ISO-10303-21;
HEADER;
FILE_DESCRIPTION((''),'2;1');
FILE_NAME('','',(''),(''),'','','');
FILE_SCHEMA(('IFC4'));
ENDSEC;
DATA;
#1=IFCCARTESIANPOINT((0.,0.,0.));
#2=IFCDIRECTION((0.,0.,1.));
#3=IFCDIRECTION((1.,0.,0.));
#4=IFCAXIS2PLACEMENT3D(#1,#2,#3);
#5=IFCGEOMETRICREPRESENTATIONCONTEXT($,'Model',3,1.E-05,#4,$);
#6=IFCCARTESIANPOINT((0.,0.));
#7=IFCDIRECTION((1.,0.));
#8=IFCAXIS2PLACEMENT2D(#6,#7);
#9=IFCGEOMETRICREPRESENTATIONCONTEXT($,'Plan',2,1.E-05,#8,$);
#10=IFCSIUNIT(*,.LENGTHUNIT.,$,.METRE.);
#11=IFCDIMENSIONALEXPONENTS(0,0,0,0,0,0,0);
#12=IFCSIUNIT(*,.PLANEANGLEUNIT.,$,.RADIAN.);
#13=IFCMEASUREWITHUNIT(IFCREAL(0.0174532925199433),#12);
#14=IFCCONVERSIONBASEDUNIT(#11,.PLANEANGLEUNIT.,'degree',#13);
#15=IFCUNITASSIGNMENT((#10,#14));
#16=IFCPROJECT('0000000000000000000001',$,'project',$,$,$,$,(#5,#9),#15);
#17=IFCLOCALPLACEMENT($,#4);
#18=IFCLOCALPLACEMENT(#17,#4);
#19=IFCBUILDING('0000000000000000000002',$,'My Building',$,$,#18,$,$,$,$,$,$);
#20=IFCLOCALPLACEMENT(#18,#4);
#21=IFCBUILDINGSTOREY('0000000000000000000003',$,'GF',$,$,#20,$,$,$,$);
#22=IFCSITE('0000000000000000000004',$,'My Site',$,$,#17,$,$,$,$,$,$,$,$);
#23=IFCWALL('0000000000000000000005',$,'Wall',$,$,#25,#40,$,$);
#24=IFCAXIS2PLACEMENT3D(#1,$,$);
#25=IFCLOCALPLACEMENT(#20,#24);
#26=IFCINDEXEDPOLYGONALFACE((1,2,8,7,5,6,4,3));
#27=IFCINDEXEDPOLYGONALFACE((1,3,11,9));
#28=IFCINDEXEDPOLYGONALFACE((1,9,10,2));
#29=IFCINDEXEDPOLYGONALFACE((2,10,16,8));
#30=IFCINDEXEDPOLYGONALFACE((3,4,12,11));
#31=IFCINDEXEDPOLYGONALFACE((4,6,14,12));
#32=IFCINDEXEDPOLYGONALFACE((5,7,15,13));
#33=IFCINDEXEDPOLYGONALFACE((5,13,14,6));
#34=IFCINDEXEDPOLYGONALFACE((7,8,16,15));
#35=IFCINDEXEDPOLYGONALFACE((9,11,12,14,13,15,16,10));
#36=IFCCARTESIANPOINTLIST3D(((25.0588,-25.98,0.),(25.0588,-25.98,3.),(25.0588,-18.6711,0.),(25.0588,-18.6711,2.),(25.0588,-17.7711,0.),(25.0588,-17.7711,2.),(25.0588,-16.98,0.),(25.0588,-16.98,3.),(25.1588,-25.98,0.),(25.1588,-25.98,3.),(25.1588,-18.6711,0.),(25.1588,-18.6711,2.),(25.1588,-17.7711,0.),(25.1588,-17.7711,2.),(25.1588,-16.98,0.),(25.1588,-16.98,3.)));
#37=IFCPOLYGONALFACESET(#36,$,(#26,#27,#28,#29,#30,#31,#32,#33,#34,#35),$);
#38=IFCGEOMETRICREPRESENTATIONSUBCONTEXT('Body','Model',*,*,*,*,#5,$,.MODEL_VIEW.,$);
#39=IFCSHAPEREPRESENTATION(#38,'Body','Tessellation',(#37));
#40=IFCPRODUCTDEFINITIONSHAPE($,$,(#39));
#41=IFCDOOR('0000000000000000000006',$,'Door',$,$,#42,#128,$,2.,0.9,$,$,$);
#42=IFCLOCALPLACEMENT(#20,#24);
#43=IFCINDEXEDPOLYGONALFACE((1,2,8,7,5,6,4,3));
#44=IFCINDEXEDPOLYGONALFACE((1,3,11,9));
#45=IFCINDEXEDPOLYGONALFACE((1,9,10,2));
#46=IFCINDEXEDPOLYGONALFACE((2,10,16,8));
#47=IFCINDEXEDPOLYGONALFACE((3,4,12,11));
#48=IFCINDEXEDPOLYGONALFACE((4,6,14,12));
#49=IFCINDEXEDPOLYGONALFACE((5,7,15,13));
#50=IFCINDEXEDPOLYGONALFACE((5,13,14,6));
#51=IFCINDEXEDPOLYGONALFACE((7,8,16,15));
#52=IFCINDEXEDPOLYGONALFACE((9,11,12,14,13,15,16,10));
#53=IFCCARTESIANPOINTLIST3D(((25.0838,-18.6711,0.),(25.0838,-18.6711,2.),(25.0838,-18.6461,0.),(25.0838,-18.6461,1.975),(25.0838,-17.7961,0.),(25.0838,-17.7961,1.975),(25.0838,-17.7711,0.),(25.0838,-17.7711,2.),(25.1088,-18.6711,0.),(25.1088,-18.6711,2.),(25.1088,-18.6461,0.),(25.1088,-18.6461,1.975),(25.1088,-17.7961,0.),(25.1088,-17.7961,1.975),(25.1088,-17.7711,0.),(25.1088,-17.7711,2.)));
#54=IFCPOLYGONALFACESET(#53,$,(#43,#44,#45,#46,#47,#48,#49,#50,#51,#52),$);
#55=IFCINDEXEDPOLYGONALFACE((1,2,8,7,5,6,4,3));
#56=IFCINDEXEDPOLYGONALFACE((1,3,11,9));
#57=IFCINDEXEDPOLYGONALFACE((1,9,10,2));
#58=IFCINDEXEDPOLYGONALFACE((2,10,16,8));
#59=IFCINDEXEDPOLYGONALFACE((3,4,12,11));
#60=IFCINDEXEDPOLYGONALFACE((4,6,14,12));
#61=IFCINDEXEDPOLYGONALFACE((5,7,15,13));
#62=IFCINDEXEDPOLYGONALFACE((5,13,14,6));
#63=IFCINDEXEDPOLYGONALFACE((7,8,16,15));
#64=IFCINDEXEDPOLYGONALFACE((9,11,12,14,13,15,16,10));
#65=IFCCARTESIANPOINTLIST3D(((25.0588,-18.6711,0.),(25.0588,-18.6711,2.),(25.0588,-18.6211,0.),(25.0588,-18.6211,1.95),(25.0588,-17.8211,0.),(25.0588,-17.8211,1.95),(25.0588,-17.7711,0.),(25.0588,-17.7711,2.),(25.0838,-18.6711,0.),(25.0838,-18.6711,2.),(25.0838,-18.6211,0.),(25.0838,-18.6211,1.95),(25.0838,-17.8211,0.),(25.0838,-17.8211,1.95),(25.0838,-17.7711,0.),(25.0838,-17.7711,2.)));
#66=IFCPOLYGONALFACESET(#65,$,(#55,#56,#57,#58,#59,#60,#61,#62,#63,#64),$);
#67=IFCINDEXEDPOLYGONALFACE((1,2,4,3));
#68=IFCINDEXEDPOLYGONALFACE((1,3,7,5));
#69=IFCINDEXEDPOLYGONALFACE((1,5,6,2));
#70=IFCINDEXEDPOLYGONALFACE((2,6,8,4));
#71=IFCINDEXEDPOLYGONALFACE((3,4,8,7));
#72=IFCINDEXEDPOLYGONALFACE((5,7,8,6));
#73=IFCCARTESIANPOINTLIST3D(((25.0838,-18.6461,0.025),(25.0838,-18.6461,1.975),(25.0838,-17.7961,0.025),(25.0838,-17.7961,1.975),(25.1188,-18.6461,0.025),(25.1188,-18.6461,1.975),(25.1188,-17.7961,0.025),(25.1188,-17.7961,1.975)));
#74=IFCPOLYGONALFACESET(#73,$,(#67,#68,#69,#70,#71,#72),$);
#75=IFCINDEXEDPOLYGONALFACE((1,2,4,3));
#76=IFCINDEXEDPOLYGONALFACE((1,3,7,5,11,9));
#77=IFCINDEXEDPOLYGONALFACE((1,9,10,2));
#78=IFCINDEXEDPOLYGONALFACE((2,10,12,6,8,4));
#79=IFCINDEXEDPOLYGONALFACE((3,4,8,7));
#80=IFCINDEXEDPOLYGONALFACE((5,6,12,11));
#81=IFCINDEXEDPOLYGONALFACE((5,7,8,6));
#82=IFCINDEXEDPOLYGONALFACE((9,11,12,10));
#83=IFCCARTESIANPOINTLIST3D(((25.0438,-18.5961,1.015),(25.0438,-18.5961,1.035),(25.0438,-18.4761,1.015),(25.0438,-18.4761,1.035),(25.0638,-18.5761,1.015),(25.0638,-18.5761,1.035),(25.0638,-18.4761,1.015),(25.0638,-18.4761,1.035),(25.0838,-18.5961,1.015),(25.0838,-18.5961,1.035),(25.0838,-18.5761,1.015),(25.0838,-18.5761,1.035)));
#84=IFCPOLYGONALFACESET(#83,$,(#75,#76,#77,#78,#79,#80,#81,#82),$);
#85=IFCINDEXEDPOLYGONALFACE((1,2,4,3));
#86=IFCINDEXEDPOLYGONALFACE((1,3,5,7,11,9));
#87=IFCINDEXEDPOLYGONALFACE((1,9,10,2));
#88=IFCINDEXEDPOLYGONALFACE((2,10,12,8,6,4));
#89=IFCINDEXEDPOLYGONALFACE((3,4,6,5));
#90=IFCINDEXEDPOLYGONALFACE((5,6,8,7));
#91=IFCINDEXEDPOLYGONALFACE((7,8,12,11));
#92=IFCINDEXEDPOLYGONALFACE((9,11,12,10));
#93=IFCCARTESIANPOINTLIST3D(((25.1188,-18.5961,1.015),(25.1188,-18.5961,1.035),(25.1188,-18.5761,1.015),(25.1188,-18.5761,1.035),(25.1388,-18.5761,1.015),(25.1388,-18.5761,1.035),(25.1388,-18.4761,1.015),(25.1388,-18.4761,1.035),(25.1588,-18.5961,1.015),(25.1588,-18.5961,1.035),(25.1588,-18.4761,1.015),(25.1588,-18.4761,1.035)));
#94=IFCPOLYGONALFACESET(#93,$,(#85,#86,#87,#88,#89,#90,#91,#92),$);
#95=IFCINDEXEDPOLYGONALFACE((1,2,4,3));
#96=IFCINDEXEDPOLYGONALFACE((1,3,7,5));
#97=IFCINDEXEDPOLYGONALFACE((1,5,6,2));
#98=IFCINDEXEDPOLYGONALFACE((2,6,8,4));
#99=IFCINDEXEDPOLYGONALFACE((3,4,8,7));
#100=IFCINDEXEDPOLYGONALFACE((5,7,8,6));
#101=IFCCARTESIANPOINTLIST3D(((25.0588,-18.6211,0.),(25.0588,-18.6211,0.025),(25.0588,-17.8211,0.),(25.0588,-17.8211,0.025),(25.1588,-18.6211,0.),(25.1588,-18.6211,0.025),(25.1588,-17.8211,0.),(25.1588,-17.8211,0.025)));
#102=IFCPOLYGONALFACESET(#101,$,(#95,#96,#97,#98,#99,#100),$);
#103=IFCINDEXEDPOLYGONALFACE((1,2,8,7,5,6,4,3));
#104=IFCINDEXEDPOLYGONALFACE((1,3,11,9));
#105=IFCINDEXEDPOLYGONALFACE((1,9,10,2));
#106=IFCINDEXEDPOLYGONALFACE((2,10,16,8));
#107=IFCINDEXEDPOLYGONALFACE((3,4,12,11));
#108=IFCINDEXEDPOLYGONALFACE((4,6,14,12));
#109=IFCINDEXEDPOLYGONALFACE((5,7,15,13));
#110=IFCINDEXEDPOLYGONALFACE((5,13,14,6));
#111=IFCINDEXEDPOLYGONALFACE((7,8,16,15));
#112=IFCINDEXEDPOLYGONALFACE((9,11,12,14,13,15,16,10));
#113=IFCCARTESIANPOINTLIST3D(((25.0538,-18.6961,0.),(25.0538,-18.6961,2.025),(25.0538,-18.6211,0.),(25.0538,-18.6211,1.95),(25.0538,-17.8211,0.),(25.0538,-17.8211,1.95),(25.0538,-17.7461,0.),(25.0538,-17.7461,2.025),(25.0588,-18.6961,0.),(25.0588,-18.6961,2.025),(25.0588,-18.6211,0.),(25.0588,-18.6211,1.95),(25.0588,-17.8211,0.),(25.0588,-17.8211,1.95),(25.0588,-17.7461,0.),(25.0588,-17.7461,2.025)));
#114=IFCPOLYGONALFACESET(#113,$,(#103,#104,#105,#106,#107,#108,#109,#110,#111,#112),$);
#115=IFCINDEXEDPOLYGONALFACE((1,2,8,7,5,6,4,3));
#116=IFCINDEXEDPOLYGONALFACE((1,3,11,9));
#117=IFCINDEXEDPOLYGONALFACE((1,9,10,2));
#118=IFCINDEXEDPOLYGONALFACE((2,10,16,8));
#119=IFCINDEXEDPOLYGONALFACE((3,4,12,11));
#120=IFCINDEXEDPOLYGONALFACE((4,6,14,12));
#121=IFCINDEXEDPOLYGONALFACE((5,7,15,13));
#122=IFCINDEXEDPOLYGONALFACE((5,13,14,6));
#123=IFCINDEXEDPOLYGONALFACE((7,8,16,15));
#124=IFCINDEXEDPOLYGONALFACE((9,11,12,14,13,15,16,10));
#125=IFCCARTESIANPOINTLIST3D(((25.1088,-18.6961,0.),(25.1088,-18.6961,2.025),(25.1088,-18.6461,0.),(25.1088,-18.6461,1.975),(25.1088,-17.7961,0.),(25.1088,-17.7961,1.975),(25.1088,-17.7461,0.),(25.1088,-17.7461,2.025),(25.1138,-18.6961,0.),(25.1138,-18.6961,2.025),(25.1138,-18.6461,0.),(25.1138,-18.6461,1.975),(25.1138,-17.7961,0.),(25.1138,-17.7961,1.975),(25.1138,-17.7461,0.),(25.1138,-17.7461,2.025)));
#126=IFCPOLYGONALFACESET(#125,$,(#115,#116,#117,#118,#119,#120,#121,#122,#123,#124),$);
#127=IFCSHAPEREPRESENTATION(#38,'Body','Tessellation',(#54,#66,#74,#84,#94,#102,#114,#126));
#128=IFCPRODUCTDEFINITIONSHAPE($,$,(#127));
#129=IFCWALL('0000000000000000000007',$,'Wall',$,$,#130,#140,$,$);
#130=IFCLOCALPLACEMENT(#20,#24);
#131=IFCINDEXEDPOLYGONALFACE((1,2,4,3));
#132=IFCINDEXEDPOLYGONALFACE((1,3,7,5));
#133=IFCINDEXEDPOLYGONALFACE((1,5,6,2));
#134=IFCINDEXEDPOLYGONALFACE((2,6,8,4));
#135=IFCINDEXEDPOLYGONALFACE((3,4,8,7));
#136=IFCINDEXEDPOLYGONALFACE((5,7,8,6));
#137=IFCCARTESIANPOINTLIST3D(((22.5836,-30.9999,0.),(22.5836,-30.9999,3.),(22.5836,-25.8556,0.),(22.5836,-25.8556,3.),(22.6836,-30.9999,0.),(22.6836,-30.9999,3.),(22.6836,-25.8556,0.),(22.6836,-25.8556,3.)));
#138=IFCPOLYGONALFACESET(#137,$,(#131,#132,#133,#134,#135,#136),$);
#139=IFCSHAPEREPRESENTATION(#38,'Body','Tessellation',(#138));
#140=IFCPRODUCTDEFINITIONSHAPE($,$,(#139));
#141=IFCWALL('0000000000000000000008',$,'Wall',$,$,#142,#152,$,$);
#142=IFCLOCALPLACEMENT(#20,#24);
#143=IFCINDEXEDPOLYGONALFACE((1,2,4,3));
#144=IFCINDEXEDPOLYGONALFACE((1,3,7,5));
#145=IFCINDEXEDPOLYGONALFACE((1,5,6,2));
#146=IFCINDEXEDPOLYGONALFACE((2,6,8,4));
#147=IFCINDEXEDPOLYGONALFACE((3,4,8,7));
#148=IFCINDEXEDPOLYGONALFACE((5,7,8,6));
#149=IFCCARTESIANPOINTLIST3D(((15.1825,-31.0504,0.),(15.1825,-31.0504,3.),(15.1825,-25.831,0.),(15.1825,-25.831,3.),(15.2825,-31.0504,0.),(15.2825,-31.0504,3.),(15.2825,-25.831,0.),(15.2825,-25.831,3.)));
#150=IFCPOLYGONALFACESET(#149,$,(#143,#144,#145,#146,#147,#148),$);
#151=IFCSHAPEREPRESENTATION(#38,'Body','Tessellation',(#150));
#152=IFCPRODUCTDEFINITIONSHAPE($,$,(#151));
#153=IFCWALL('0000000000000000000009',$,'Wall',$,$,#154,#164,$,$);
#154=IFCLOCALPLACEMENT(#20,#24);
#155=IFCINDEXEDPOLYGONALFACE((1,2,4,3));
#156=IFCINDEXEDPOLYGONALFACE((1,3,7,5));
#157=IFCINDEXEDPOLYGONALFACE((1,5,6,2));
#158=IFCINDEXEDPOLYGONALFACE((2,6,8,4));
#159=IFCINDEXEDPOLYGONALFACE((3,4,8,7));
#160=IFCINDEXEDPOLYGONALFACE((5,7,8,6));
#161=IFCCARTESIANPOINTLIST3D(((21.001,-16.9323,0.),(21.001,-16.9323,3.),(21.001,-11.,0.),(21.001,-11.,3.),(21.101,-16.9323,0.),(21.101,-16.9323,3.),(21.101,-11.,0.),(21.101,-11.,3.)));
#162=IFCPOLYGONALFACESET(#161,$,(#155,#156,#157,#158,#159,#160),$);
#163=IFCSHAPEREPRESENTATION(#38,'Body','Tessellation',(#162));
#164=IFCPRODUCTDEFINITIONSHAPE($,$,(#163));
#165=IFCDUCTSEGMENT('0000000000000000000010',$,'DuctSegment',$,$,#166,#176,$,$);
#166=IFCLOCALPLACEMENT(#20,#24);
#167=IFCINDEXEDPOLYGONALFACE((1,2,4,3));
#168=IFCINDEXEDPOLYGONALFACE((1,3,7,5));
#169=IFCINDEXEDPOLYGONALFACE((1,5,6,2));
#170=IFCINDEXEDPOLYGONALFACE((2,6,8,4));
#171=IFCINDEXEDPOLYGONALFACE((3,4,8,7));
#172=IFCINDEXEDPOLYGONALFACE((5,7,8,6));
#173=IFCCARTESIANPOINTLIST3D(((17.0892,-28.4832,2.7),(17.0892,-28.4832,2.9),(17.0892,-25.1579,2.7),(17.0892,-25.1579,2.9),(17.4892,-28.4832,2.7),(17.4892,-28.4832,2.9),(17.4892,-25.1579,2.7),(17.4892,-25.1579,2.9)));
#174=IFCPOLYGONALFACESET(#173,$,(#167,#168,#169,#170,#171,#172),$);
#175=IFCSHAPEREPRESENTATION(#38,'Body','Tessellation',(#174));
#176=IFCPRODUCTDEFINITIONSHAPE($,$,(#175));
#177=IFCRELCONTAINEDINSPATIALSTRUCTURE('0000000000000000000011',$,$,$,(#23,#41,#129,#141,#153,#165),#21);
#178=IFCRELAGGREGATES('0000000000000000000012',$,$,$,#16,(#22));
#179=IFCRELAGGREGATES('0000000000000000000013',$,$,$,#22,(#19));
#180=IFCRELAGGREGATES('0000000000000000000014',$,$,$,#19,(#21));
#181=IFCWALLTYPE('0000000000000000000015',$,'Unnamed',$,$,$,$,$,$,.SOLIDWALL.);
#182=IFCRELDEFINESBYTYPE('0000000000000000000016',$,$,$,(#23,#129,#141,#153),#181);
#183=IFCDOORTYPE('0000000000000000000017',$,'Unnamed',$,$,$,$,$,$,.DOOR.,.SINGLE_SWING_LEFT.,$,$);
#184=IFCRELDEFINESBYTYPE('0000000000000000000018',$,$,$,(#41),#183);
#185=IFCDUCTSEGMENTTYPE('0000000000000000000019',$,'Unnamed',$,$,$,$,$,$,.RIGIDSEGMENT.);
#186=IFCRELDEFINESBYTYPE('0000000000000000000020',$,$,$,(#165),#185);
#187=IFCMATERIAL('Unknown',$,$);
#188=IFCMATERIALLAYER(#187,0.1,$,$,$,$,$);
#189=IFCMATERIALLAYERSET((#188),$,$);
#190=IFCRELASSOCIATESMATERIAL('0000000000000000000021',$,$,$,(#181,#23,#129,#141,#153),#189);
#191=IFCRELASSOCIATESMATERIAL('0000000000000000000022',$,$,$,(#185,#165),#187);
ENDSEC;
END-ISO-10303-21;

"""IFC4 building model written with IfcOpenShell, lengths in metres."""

from ifc_helpers import new_model, entity, si_unit, converted_unit, frame, origin_with_axes, origin_2d_with_axis, place, context, subcontext, project, spatial, line, indexed_curve, rectangle, outline, extrude, shape, source, transform, mapped, material, layer, layer_set, layer_usage, material_profile, profile_set, profile_usage, type_object, type_shapes, element, fill, save


model = new_model("IFC4")

# Units and contexts
model_context = context("Model", 3, precision=1e-05, world=origin_with_axes())
plan_context = context("Plan", 2, precision=1e-05, world=origin_2d_with_axis())
body_context_1 = subcontext(model_context, "Body", "Model", "MODEL_VIEW")
body_context_2 = subcontext(plan_context, "Body", "Plan", "PLAN_VIEW")
ifc_project = project(units=[si_unit("LENGTHUNIT", "METRE"), converted_unit("PLANEANGLEUNIT", "degree", entity("IfcReal", 0.0174532925199433), si_unit("PLANEANGLEUNIT", "RADIAN"), dimensions=[0, 0, 0, 0, 0, 0, 0])], contexts=[model_context, plan_context])

# Site, building, storey
site_placement = place(None, origin_with_axes())
site = spatial("IfcSite", under=ifc_project, at=site_placement, Name="My Site")
building_placement = place(site_placement, origin_with_axes())
building = spatial("IfcBuilding", under=site, at=building_placement, Name="My Building")
storey_placement = place(building_placement, origin_with_axes())
storey = spatial("IfcBuildingStorey", under=building, at=storey_placement, Name="GF")

# Shared definitions
ifc_material = material(Name="Unknown")
ifc_layer = layer(ifc_material, 0.1)
ifc_layer_set = layer_set([ifc_layer])
wall_type = type_object("IfcWallType", Name="Unnamed", PredefinedType="SOLIDWALL", material=ifc_layer_set)

# Shared definitions
shared_shape_1 = source(origin_with_axes(), body_context_1, "Body", "SweptSolid", [
    extrude(outline(indexed_curve([(0.0, 0.0), (0.9, 0.0), (0.9, 2.0), (0.0, 2.0)], segments=[line(1, 2, 3, 4, 1)])), frame((0.0, -0.6, 0.0), z_axis=(0.0, -1.0, 0.0), x_axis=(1.0, 0.0, 0.0)), (0.0, 0.0, -1.0), 1.2),
])
door_type = type_object("IfcDoorType", Name="Unnamed", OperationType="SINGLE_SWING_LEFT", PredefinedType="DOOR")
shared_shape_2 = source(origin_with_axes(), body_context_1, "Body", "SweptSolid", [
    extrude(outline(indexed_curve([(0.0, 0.0), (0.0, 2.0), (0.9, 2.0), (0.9, 0.0), (0.875, 0.0), (0.875, 1.975), (0.025, 1.975), (0.025, 0.0)], segments=[line(1, 2, 3, 4, 5, 6, 7, 8, 1)])), frame((0.0, 0.025, 0.0), z_axis=(0.0, -1.0, 0.0), x_axis=(1.0, 0.0, 0.0)), (0.0, 0.0, -1.0), 0.025),
    extrude(outline(indexed_curve([(0.0, 0.0), (0.0, 2.0), (0.9, 2.0), (0.9, 0.0), (0.85, 0.0), (0.85, 1.95), (0.05, 1.95), (0.05, 0.0)], segments=[line(1, 2, 3, 4, 5, 6, 7, 8, 1)])), frame((0.0, 0.0, 0.0), z_axis=(0.0, -1.0, 0.0), x_axis=(1.0, 0.0, 0.0)), (0.0, 0.0, -1.0), 0.025),
    extrude(outline(indexed_curve([(0.0, 0.0), (0.85, 0.0), (0.85, 0.035), (0.0, 0.035)], segments=[line(1, 2, 3, 4, 1)])), frame((0.025, 0.025, 0.025), z_axis=(0.0, 0.0, 1.0), x_axis=(1.0, 0.0, 0.0)), (0.0, 0.0, 1.0), 1.95),
    extrude(outline(indexed_curve([(0.0, 0.0), (0.0, -0.04), (-0.12, -0.04), (-0.12, -0.02), (-0.02, -0.02), (-0.02, 0.0)], segments=[line(1, 2, 3, 4, 5, 6, 1)])), frame((0.825, 0.025, 1.015), z_axis=(0.0, 0.0, 1.0), x_axis=(1.0, 0.0, 0.0)), (0.0, 0.0, 1.0), 0.02),
    extrude(outline(indexed_curve([(0.0, 0.0), (0.0, 0.04), (-0.12, 0.04), (-0.12, 0.02), (-0.02, 0.02), (-0.02, 0.0)], segments=[line(1, 2, 3, 4, 5, 6, 1)])), frame((0.825, 0.06, 1.015), z_axis=(0.0, 0.0, 1.0), x_axis=(1.0, 0.0, 0.0)), (0.0, 0.0, 1.0), 0.02),
    extrude(outline(indexed_curve([(0.0, 0.0), (0.8, 0.0), (0.8, 0.1), (0.0, 0.1)], segments=[line(1, 2, 3, 4, 1)])), frame((0.05, 0.0, 0.0), z_axis=(0.0, 0.0, 1.0), x_axis=(1.0, 0.0, 0.0)), (0.0, 0.0, 1.0), 0.025),
    extrude(outline(indexed_curve([(0.0, 0.0), (0.0, 2.025), (0.95, 2.025), (0.95, 0.0), (0.875, 0.0), (0.875, 1.95), (0.075, 1.95), (0.075, 0.0)], segments=[line(1, 2, 3, 4, 5, 6, 7, 8, 1)])), frame((-0.025, -0.005, 0.0), z_axis=(0.0, -1.0, 0.0), x_axis=(1.0, 0.0, 0.0)), (0.0, 0.0, -1.0), 0.005),
    extrude(outline(indexed_curve([(0.0, 0.0), (0.0, 2.025), (0.95, 2.025), (0.95, 0.0), (0.9, 0.0), (0.9, 1.975), (0.05, 1.975), (0.05, 0.0)], segments=[line(1, 2, 3, 4, 5, 6, 7, 8, 1)])), frame((-0.025, 0.05, 0.0), z_axis=(0.0, -1.0, 0.0), x_axis=(1.0, 0.0, 0.0)), (0.0, 0.0, -1.0), 0.005),
])
shared_shape_3 = source(origin_with_axes(), body_context_2, "Body", "Curve2D", [
    entity("IfcIndexedPolyCurve", entity("IfcCartesianPointList2D", [[0.0, 0.0], [0.0, 0.05], [0.025, 0.05], [0.025, 0.025], [0.05, 0.025], [0.05, 0.0]]), [entity("IfcLineIndex", [1, 2, 3, 4, 5, 6, 1])]),
    entity("IfcIndexedPolyCurve", entity("IfcCartesianPointList2D", [[0.9, 0.0], [0.9, 0.05], [0.875, 0.05], [0.875, 0.025], [0.85, 0.025], [0.85, 0.0]]), [entity("IfcLineIndex", [1, 2, 3, 4, 5, 6, 1])]),
    entity("IfcTrimmedCurve", entity("IfcEllipse", entity("IfcAxis2Placement2D", entity("IfcCartesianPoint", [0.06, 0.05]), entity("IfcDirection", [1.0, 0.0])), 0.815, 0.85), [entity("IfcCartesianPoint", [0.875, 0.05])], [entity("IfcCartesianPoint", [0.06, 0.9])], True, "CARTESIAN"),
    entity("IfcIndexedPolyCurve", entity("IfcCartesianPointList2D", [[0.025, 0.05], [0.06, 0.05], [0.06, 0.9], [0.025, 0.9]]), [entity("IfcLineIndex", [1, 2, 3, 4, 1])]),
])
type_shapes(door_type, [shared_shape_2, shared_shape_3])

# Wall, opening, door
ifc_layer_usage_1 = layer_usage(ifc_layer_set, "AXIS2", "POSITIVE", 0.0)
wall_1_placement = place(storey_placement, frame((25.0588, -16.98, 0.0), z_axis=(0.0, 0.0, 1.0), x_axis=(0.0, -1.0, 0.0)))
wall_1 = element("IfcWall", 1, at=wall_1_placement, inside=storey, type_object=wall_type, material=ifc_layer_usage_1, Name="Wall", context=body_context_1, shape_type="SweptSolid", body=[
    extrude(outline(indexed_curve([(0.0, 0.0), (0.0, 0.1), (9.0, 0.1), (9.0, 0.0)], segments=[line(1, 2, 3, 4, 1)])), origin_with_axes(), (0.0, 0.0, 1.0), 3.0),
])
opening_1_placement = place(wall_1_placement, frame((0.7911, 0.0, 0.0), z_axis=(0.0, 0.0, 1.0), x_axis=(1.0, 0.0, 0.0)))
opening_1 = element("IfcOpeningElement", 2, at=opening_1_placement, cuts=wall_1, PredefinedType="OPENING", context=body_context_1, shape_type="MappedRepresentation", body=[
    mapped(shared_shape_1, transform((0.0, 0.0, 0.0), x_axis=(1.0, 0.0, 0.0), y_axis=(0.0, 1.0, 0.0), z_axis=(0.0, 0.0, 1.0), scale=1.0)),
])
door_1_placement = place(opening_1_placement, frame((0.0, 0.0, 0.0), z_axis=(0.0, 0.0, 1.0), x_axis=(1.0, 0.0, 0.0)))
door_1 = element("IfcDoor", 3, at=door_1_placement, inside=storey, type_object=door_type, Name="Door", OverallHeight=2.0, OverallWidth=0.9, shapes=[
    shape(body_context_1, "Body", "MappedRepresentation", [mapped(shared_shape_2, transform((0.0, 0.0, 0.0), x_axis=(1.0, 0.0, 0.0), y_axis=(0.0, 1.0, 0.0), z_axis=(0.0, 0.0, 1.0), scale=1.0))]),
    shape(body_context_2, "Body", "MappedRepresentation", [mapped(shared_shape_3, transform((0.0, 0.0, 0.0), x_axis=(1.0, 0.0, 0.0), y_axis=(0.0, 1.0, 0.0), z_axis=(0.0, 0.0, 1.0), scale=1.0))]),
])
fill(opening_1, door_1)

# Walls
ifc_layer_usage_2 = layer_usage(ifc_layer_set, "AXIS2", "POSITIVE", 0.0)
wall_2_placement = place(storey_placement, frame((22.5836, -25.8556, 0.0), z_axis=(0.0, 0.0, 1.0), x_axis=(0.0, -1.0, 0.0)))
element("IfcWall", 4, at=wall_2_placement, inside=storey, type_object=wall_type, material=ifc_layer_usage_2, Name="Wall", context=body_context_1, shape_type="SweptSolid", body=[
    extrude(outline(indexed_curve([(0.0, 0.0), (0.0, 0.1), (5.1443, 0.1), (5.1443, 0.0)], segments=[line(1, 2, 3, 4, 1)])), origin_with_axes(), (0.0, 0.0, 1.0), 3.0),
])
ifc_layer_usage_3 = layer_usage(ifc_layer_set, "AXIS2", "POSITIVE", 0.0)
wall_3_placement = place(storey_placement, frame((15.1825, -25.831, 0.0), z_axis=(0.0, 0.0, 1.0), x_axis=(0.0, -1.0, 0.0)))
element("IfcWall", 5, at=wall_3_placement, inside=storey, type_object=wall_type, material=ifc_layer_usage_3, Name="Wall", context=body_context_1, shape_type="SweptSolid", body=[
    extrude(outline(indexed_curve([(0.0, 0.0), (0.0, 0.1), (5.2194, 0.1), (5.2194, 0.0)], segments=[line(1, 2, 3, 4, 1)])), origin_with_axes(), (0.0, 0.0, 1.0), 3.0),
])
ifc_layer_usage_4 = layer_usage(ifc_layer_set, "AXIS2", "POSITIVE", 0.0)
wall_4_placement = place(storey_placement, frame((21.101, -16.9323, 0.0), z_axis=(0.0, 0.0, 1.0), x_axis=(0.0, 1.0, 0.0)))
element("IfcWall", 6, at=wall_4_placement, inside=storey, type_object=wall_type, material=ifc_layer_usage_4, Name="Wall", context=body_context_1, shape_type="SweptSolid", body=[
    extrude(outline(indexed_curve([(0.0, 0.0), (0.0, 0.1), (5.9323, 0.1), (5.9323, 0.0)], segments=[line(1, 2, 3, 4, 1)])), origin_with_axes(), (0.0, 0.0, 1.0), 3.0),
])

# Duct segment
ifc_material_profile_1 = material_profile(ifc_material, rectangle(XDim=0.4, YDim=0.2))
ifc_profile_set_1 = profile_set([ifc_material_profile_1])
ifc_profile_usage_1 = profile_usage(ifc_profile_set_1, cardinal=5)
duct_segment_type = type_object("IfcDuctSegmentType", Name="Unnamed", PredefinedType="RIGIDSEGMENT", material=ifc_profile_set_1)
duct_segment_1_placement = place(storey_placement, frame((17.2892, -25.1579, 2.8), z_axis=(0.0, -1.0, 0.0), x_axis=(1.0, 0.0, 0.0)))
element("IfcDuctSegment", 7, at=duct_segment_1_placement, inside=storey, type_object=duct_segment_type, material=ifc_profile_usage_1, Name="DuctSegment", context=body_context_1, shape_type="SweptSolid", body=[
    extrude(rectangle(XDim=0.4, YDim=0.2), origin_with_axes(), (0.0, 0.0, 1.0), 3.3252),
])

save(model, "model.ifc")
